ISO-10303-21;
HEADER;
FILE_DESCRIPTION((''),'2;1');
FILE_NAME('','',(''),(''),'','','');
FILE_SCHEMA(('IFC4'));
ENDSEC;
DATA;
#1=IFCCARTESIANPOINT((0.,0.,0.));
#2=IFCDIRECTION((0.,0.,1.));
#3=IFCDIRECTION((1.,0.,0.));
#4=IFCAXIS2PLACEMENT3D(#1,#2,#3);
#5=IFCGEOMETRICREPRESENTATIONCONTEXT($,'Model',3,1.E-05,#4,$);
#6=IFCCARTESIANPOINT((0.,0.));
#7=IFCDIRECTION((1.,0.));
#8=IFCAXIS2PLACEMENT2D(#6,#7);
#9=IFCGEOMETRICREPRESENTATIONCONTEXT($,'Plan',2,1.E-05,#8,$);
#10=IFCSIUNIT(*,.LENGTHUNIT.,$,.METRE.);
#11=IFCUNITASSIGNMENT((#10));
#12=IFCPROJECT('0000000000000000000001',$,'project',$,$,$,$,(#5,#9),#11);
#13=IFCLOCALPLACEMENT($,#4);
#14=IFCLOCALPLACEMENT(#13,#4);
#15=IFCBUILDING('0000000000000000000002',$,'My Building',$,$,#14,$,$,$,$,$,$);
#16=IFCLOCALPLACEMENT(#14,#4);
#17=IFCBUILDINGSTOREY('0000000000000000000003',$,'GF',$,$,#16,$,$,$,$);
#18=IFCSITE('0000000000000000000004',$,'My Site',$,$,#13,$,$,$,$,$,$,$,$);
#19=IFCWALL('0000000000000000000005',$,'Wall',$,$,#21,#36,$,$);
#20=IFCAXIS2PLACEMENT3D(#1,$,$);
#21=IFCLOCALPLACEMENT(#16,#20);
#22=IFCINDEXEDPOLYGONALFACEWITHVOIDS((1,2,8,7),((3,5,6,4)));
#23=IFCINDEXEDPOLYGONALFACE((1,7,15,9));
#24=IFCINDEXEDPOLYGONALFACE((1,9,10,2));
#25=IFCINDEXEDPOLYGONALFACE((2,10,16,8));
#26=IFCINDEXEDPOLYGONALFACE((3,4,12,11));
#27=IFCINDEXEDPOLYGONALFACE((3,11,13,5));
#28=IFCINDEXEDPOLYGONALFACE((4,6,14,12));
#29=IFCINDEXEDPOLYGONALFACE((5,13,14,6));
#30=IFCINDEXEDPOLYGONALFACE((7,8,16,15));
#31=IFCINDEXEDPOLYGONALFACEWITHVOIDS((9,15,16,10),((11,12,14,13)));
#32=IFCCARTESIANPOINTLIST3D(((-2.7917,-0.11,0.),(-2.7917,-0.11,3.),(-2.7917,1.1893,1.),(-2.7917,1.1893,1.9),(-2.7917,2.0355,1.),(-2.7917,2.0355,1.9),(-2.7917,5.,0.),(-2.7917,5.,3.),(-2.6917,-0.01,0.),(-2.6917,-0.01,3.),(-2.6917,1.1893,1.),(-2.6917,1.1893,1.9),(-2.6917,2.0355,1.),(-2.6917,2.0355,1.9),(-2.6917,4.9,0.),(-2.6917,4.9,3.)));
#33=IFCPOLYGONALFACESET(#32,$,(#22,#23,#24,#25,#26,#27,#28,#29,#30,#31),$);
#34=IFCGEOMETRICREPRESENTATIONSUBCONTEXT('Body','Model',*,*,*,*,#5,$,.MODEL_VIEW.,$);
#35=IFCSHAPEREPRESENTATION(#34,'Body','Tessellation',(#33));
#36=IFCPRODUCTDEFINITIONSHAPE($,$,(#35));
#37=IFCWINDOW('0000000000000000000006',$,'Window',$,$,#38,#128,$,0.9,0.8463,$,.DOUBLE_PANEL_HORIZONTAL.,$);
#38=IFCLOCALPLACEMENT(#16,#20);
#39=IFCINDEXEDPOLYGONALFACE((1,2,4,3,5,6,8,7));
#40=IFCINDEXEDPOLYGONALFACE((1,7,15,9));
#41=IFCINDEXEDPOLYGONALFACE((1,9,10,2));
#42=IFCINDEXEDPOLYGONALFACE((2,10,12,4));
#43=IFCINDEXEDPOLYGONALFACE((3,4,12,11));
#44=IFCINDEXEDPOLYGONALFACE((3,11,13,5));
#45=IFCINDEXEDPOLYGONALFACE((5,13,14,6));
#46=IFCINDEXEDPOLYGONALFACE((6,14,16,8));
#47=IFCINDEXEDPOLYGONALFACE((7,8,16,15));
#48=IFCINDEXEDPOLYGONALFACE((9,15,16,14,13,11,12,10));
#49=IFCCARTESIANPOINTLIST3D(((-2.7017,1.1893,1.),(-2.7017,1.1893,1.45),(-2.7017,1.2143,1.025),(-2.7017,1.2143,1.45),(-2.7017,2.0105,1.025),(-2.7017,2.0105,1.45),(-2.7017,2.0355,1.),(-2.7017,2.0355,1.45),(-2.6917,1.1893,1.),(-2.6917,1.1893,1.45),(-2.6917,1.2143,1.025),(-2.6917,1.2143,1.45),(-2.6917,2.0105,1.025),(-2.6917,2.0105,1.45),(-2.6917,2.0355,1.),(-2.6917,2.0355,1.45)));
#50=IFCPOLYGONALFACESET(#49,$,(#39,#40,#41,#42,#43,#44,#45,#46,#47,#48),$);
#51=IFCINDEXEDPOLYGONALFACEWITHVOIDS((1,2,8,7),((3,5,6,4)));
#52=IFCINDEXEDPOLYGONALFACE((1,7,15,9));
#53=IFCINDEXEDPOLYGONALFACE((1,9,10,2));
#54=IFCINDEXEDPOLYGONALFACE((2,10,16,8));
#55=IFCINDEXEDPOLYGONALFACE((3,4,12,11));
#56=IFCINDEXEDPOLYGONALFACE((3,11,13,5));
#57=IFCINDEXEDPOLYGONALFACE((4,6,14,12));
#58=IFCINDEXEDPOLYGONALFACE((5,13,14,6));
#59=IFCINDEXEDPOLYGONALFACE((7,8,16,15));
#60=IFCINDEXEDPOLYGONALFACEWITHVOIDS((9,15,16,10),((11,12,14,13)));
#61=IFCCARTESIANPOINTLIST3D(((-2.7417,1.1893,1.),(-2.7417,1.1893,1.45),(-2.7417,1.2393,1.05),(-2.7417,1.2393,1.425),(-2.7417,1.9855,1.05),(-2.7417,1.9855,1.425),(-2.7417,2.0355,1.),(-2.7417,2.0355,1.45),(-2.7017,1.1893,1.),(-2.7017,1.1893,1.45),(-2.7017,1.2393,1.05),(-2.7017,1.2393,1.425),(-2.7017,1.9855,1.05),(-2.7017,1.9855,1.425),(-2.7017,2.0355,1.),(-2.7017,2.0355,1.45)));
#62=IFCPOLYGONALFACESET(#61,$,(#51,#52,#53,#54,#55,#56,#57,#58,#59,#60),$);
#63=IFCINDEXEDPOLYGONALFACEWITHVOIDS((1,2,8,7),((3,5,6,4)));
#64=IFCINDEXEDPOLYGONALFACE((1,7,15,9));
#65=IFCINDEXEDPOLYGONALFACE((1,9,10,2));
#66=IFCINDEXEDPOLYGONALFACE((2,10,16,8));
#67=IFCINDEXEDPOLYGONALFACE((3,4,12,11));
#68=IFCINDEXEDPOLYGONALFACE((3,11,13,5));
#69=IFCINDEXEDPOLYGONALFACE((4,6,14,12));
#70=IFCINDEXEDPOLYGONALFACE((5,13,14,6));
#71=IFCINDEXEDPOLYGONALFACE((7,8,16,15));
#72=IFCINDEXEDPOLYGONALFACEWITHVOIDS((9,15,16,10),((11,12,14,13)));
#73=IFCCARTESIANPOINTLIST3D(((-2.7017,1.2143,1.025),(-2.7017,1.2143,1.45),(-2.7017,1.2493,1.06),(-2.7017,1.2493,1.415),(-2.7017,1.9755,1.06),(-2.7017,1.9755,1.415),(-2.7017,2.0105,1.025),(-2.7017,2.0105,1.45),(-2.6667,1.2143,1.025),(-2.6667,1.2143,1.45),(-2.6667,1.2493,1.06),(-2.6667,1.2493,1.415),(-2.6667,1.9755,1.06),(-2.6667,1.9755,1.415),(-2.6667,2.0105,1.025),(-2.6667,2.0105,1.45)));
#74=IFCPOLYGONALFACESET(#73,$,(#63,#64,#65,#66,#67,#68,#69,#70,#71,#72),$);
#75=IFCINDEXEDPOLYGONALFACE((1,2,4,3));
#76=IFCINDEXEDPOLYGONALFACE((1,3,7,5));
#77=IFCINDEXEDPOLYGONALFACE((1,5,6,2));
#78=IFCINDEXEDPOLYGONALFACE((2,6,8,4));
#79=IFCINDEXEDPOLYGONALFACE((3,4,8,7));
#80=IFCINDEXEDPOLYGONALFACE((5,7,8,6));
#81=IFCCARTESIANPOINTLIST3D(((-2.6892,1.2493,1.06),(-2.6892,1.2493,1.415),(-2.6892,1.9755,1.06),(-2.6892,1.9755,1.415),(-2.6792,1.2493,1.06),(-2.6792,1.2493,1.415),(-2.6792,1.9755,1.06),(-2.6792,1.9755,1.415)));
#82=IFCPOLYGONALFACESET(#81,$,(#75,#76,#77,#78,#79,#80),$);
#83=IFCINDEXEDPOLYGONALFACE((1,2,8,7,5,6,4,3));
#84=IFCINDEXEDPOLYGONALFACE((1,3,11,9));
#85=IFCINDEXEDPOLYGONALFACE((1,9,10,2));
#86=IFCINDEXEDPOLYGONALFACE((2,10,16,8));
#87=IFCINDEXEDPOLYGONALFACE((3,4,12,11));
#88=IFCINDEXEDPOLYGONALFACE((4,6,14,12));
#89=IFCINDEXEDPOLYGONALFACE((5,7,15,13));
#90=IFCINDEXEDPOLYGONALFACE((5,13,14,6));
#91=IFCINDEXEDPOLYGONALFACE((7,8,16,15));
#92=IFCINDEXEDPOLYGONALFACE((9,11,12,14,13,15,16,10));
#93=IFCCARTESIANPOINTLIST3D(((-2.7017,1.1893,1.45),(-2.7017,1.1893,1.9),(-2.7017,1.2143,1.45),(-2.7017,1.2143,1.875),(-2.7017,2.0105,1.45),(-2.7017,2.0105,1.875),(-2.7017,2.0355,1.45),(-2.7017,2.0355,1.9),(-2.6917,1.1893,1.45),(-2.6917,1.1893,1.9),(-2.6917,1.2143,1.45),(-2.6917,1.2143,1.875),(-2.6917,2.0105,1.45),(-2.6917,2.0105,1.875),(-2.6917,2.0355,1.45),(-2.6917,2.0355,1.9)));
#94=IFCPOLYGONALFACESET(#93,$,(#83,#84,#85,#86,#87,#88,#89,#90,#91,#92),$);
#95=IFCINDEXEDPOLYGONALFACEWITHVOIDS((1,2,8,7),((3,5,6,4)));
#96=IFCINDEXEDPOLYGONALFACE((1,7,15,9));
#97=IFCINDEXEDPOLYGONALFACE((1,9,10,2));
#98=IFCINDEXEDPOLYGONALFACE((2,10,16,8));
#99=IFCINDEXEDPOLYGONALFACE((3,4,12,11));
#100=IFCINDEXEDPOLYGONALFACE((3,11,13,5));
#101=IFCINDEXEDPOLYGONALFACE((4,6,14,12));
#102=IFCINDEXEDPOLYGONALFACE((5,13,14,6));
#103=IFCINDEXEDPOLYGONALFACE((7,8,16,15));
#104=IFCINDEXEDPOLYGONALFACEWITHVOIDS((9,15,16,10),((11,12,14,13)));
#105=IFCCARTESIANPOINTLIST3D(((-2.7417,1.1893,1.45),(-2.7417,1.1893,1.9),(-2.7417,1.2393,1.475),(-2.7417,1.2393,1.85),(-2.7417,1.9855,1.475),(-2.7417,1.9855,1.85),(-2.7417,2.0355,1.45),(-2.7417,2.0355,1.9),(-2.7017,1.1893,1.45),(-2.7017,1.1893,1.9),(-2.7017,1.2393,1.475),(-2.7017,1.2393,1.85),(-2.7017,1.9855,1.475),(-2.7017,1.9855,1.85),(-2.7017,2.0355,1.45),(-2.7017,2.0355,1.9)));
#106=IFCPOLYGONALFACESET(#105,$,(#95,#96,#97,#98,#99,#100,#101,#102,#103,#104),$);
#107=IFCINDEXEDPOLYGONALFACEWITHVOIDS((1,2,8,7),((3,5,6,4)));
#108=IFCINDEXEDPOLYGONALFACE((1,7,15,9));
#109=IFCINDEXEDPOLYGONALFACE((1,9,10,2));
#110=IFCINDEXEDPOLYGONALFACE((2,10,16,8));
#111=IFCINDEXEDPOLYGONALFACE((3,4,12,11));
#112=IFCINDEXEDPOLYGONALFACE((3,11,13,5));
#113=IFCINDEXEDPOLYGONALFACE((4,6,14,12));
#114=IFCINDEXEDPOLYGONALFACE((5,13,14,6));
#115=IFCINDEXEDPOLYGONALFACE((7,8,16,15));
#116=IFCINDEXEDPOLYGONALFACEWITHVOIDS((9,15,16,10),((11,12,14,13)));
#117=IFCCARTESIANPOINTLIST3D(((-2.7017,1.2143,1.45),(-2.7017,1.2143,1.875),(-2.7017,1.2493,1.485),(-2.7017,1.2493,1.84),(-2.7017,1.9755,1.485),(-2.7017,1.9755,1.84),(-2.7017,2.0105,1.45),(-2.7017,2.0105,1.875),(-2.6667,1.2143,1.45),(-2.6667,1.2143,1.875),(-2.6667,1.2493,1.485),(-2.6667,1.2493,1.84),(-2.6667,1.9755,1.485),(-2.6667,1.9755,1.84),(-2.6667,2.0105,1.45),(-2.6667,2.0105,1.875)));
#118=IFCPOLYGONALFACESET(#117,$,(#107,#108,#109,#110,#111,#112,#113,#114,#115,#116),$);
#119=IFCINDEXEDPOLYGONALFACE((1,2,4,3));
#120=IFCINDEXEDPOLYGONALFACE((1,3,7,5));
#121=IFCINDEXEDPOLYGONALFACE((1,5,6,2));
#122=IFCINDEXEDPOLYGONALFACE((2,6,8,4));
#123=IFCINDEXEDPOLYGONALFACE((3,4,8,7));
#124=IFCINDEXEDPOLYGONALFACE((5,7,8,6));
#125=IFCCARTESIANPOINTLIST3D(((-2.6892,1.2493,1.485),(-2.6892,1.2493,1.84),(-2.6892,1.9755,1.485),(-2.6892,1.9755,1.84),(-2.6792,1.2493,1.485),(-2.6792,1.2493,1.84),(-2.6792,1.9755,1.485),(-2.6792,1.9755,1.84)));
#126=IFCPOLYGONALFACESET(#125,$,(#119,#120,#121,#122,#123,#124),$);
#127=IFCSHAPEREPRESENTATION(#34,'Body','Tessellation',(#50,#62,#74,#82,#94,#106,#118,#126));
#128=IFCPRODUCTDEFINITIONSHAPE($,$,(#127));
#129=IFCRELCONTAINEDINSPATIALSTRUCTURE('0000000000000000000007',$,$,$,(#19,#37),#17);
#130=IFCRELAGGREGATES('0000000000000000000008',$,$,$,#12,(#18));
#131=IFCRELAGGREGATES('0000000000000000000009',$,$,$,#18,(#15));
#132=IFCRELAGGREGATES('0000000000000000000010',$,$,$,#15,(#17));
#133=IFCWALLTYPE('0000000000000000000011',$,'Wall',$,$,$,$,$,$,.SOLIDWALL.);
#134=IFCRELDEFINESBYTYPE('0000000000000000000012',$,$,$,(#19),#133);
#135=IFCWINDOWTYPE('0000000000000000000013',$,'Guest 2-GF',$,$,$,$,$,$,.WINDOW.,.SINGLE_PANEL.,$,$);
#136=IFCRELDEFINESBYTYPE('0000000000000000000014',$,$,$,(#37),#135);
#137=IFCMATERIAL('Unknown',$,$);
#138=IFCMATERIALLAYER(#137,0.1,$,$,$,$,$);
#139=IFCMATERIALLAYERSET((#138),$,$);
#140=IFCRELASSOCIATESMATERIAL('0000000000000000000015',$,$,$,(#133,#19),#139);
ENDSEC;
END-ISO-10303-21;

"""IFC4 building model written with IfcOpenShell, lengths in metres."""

from ifc_helpers import new_model, entity, si_unit, frame, origin_with_axes, origin_2d_with_axis, place, context, subcontext, project, spatial, line, indexed_curve, outline, extrude, shape, source, transform, mapped, material, layer, layer_set, layer_usage, type_object, type_shapes, element, fill, save


model = new_model("IFC4")

# Units and contexts
model_context = context("Model", 3, precision=1e-05, world=origin_with_axes())
plan_context = context("Plan", 2, precision=1e-05, world=origin_2d_with_axis())
body_context_1 = subcontext(model_context, "Body", "Model", "MODEL_VIEW")
body_context_2 = subcontext(plan_context, "Body", "Plan", "PLAN_VIEW")
ifc_project = project(units=[si_unit("LENGTHUNIT", "METRE")], contexts=[model_context, plan_context])

# Site, building, storey
site_placement = place(None, origin_with_axes())
site = spatial("IfcSite", under=ifc_project, at=site_placement, Name="My Site")
building_placement = place(site_placement, origin_with_axes())
building = spatial("IfcBuilding", under=site, at=building_placement, Name="My Building")
storey_placement = place(building_placement, origin_with_axes())
storey = spatial("IfcBuildingStorey", under=building, at=storey_placement, Name="GF")

# Shared definitions
ifc_material = material(Name="Unknown")

# Shared definitions
ifc_layer_1 = layer(ifc_material, 0.1)
ifc_layer_set_1 = layer_set([ifc_layer_1])
wall_type = type_object("IfcWallType", Name="Wall", PredefinedType="SOLIDWALL", material=ifc_layer_set_1)

# Wall, opening, window
ifc_layer_usage_1 = layer_usage(ifc_layer_set_1, "AXIS2", "POSITIVE", 0.0)
wall_1_placement = place(storey_placement, frame((-2.7917, 5.0, 0.0), z_axis=(0.0, 0.0, 1.0), x_axis=(0.0, -1.0, 0.0)))
wall_1 = element("IfcWall", 1, at=wall_1_placement, inside=storey, type_object=wall_type, material=ifc_layer_usage_1, Name="Wall", context=body_context_1, shape_type="SweptSolid", body=[
    extrude(outline(indexed_curve([(0.0, 0.0), (0.1, 0.1), (5.01, 0.1), (5.11, 0.0)], segments=[line(1, 2, 3, 4, 1)])), origin_with_axes(), (0.0, 0.0, 1.0), 3.0),
])
shared_shape_1 = source(origin_with_axes(), body_context_1, "Body", "SweptSolid", [
    extrude(outline(indexed_curve([(0.0, 0.0), (0.8463, 0.0), (0.8463, 0.9), (0.0, 0.9)], segments=[line(1, 2, 3, 4, 1)])), frame((0.0, -0.6, 0.0), z_axis=(0.0, -1.0, 0.0), x_axis=(1.0, 0.0, 0.0)), (0.0, 0.0, -1.0), 1.2),
])
opening_1_placement = place(wall_1_placement, frame((2.9644, 0.0, 1.0), z_axis=(0.0, 0.0, 1.0), x_axis=(1.0, 0.0, 0.0)))
opening_1 = element("IfcOpeningElement", 2, at=opening_1_placement, cuts=wall_1, PredefinedType="OPENING", context=body_context_1, shape_type="MappedRepresentation", body=[
    mapped(shared_shape_1, transform((0.0, 0.0, 0.0), x_axis=(1.0, 0.0, 0.0), y_axis=(0.0, 1.0, 0.0), z_axis=(0.0, 0.0, 1.0), scale=1.0)),
])
window_type_1 = type_object("IfcWindowType", Name="Guest 2-GF", PartitioningType="SINGLE_PANEL", PredefinedType="WINDOW")
shared_shape_2 = source(origin_with_axes(), body_context_1, "Body", "SweptSolid", [
    extrude(outline(indexed_curve([(0.8463, 0.45), (0.8463, 0.0), (0.0, 0.0), (0.0, 0.45), (0.025, 0.45), (0.025, 0.025), (0.8213, 0.025), (0.8213, 0.45)], segments=[line(1, 2, 3, 4, 5, 6, 7, 8, 1)])), frame((0.0, 0.09, 0.0), z_axis=(0.0, -1.0, 0.0), x_axis=(1.0, 0.0, 0.0)), (0.0, 0.0, -1.0), 0.01),
    extrude(outline(indexed_curve([(0.0, 0.0), (0.8463, 0.0), (0.8463, 0.45), (0.0, 0.45)], segments=[line(1, 2, 3, 4, 1)]), holes=[indexed_curve([(0.05, 0.05), (0.7963, 0.05), (0.7963, 0.425), (0.05, 0.425)], segments=[line(1, 2, 3, 4, 1)])]), frame((0.0, 0.05, 0.0), z_axis=(0.0, -1.0, 0.0), x_axis=(1.0, 0.0, 0.0)), (0.0, 0.0, -1.0), 0.04),
    extrude(outline(indexed_curve([(0.0, 0.0), (0.7963, 0.0), (0.7963, 0.425), (0.0, 0.425)], segments=[line(1, 2, 3, 4, 1)]), holes=[indexed_curve([(0.035, 0.035), (0.7613, 0.035), (0.7613, 0.39), (0.035, 0.39)], segments=[line(1, 2, 3, 4, 1)])]), frame((0.025, 0.09, 0.025), z_axis=(0.0, -1.0, 0.0), x_axis=(1.0, 0.0, 0.0)), (0.0, 0.0, -1.0), 0.035),
    extrude(outline(indexed_curve([(0.035, 0.035), (0.7613, 0.035), (0.7613, 0.39), (0.035, 0.39)], segments=[line(1, 2, 3, 4, 1)])), frame((0.025, 0.1025, 0.025), z_axis=(0.0, -1.0, 0.0), x_axis=(1.0, 0.0, 0.0)), (0.0, 0.0, -1.0), 0.01),
    extrude(outline(indexed_curve([(0.0, 0.0), (0.0, 0.45), (0.8463, 0.45), (0.8463, 0.0), (0.8213, 0.0), (0.8213, 0.425), (0.025, 0.425), (0.025, 0.0)], segments=[line(1, 2, 3, 4, 5, 6, 7, 8, 1)])), frame((0.0, 0.09, 0.45), z_axis=(0.0, -1.0, 0.0), x_axis=(1.0, 0.0, 0.0)), (0.0, 0.0, -1.0), 0.01),
    extrude(outline(indexed_curve([(0.0, 0.0), (0.8463, 0.0), (0.8463, 0.45), (0.0, 0.45)], segments=[line(1, 2, 3, 4, 1)]), holes=[indexed_curve([(0.05, 0.025), (0.7963, 0.025), (0.7963, 0.4), (0.05, 0.4)], segments=[line(1, 2, 3, 4, 1)])]), frame((0.0, 0.05, 0.45), z_axis=(0.0, -1.0, 0.0), x_axis=(1.0, 0.0, 0.0)), (0.0, 0.0, -1.0), 0.04),
    extrude(outline(indexed_curve([(0.0, 0.0), (0.7963, 0.0), (0.7963, 0.425), (0.0, 0.425)], segments=[line(1, 2, 3, 4, 1)]), holes=[indexed_curve([(0.035, 0.035), (0.7613, 0.035), (0.7613, 0.39), (0.035, 0.39)], segments=[line(1, 2, 3, 4, 1)])]), frame((0.025, 0.09, 0.45), z_axis=(0.0, -1.0, 0.0), x_axis=(1.0, 0.0, 0.0)), (0.0, 0.0, -1.0), 0.035),
    extrude(outline(indexed_curve([(0.035, 0.035), (0.7613, 0.035), (0.7613, 0.39), (0.035, 0.39)], segments=[line(1, 2, 3, 4, 1)])), frame((0.025, 0.1025, 0.45), z_axis=(0.0, -1.0, 0.0), x_axis=(1.0, 0.0, 0.0)), (0.0, 0.0, -1.0), 0.01),
])
shared_shape_3 = source(origin_with_axes(), body_context_2, "Body", "Curve2D", [
    entity("IfcIndexedPolyCurve", entity("IfcCartesianPointList2D", [[0.05, 0.05], [0.7963, 0.05]])),
    entity("IfcIndexedPolyCurve", entity("IfcCartesianPointList2D", [[0.0, 0.1], [0.025, 0.1], [0.025, 0.09], [0.05, 0.09], [0.05, 0.05], [0.0, 0.05]]), [entity("IfcLineIndex", [1, 2, 3, 4, 5, 6, 1])]),
    entity("IfcIndexedPolyCurve", entity("IfcCartesianPointList2D", [[0.8463, 0.1], [0.8213, 0.1], [0.8213, 0.09], [0.7963, 0.09], [0.7963, 0.05], [0.8463, 0.05]]), [entity("IfcLineIndex", [1, 2, 3, 4, 5, 6, 1])]),
    entity("IfcIndexedPolyCurve", entity("IfcCartesianPointList2D", [[0.025, 0.09], [0.06, 0.09], [0.06, 0.125], [0.025, 0.125]]), [entity("IfcLineIndex", [1, 2, 3, 4, 1])]),
    entity("IfcIndexedPolyCurve", entity("IfcCartesianPointList2D", [[0.8213, 0.09], [0.7863, 0.09], [0.7863, 0.125], [0.8213, 0.125]]), [entity("IfcLineIndex", [1, 2, 3, 4, 1])]),
    entity("IfcIndexedPolyCurve", entity("IfcCartesianPointList2D", [[0.06, 0.09], [0.7863, 0.09]])),
    entity("IfcIndexedPolyCurve", entity("IfcCartesianPointList2D", [[0.06, 0.125], [0.7863, 0.125]])),
    entity("IfcIndexedPolyCurve", entity("IfcCartesianPointList2D", [[0.06, 0.1075], [0.7863, 0.1075]])),
])
type_shapes(window_type_1, [shared_shape_2, shared_shape_3])
window_1_placement = place(opening_1_placement, frame((0.0, 0.0, 0.0), z_axis=(0.0, 0.0, 1.0), x_axis=(1.0, 0.0, 0.0)))
window_1 = element("IfcWindow", 3, at=window_1_placement, inside=storey, type_object=window_type_1, Name="Window", OverallHeight=0.9, OverallWidth=0.8463, PartitioningType="DOUBLE_PANEL_HORIZONTAL", shapes=[
    shape(body_context_1, "Body", "MappedRepresentation", [mapped(shared_shape_2, transform((0.0, 0.0, 0.0), x_axis=(1.0, 0.0, 0.0), y_axis=(0.0, 1.0, 0.0), z_axis=(0.0, 0.0, 1.0), scale=1.0))]),
    shape(body_context_2, "Body", "MappedRepresentation", [mapped(shared_shape_3, transform((0.0, 0.0, 0.0), x_axis=(1.0, 0.0, 0.0), y_axis=(0.0, 1.0, 0.0), z_axis=(0.0, 0.0, 1.0), scale=1.0))]),
])
fill(opening_1, window_1)

save(model, "model.ifc")
